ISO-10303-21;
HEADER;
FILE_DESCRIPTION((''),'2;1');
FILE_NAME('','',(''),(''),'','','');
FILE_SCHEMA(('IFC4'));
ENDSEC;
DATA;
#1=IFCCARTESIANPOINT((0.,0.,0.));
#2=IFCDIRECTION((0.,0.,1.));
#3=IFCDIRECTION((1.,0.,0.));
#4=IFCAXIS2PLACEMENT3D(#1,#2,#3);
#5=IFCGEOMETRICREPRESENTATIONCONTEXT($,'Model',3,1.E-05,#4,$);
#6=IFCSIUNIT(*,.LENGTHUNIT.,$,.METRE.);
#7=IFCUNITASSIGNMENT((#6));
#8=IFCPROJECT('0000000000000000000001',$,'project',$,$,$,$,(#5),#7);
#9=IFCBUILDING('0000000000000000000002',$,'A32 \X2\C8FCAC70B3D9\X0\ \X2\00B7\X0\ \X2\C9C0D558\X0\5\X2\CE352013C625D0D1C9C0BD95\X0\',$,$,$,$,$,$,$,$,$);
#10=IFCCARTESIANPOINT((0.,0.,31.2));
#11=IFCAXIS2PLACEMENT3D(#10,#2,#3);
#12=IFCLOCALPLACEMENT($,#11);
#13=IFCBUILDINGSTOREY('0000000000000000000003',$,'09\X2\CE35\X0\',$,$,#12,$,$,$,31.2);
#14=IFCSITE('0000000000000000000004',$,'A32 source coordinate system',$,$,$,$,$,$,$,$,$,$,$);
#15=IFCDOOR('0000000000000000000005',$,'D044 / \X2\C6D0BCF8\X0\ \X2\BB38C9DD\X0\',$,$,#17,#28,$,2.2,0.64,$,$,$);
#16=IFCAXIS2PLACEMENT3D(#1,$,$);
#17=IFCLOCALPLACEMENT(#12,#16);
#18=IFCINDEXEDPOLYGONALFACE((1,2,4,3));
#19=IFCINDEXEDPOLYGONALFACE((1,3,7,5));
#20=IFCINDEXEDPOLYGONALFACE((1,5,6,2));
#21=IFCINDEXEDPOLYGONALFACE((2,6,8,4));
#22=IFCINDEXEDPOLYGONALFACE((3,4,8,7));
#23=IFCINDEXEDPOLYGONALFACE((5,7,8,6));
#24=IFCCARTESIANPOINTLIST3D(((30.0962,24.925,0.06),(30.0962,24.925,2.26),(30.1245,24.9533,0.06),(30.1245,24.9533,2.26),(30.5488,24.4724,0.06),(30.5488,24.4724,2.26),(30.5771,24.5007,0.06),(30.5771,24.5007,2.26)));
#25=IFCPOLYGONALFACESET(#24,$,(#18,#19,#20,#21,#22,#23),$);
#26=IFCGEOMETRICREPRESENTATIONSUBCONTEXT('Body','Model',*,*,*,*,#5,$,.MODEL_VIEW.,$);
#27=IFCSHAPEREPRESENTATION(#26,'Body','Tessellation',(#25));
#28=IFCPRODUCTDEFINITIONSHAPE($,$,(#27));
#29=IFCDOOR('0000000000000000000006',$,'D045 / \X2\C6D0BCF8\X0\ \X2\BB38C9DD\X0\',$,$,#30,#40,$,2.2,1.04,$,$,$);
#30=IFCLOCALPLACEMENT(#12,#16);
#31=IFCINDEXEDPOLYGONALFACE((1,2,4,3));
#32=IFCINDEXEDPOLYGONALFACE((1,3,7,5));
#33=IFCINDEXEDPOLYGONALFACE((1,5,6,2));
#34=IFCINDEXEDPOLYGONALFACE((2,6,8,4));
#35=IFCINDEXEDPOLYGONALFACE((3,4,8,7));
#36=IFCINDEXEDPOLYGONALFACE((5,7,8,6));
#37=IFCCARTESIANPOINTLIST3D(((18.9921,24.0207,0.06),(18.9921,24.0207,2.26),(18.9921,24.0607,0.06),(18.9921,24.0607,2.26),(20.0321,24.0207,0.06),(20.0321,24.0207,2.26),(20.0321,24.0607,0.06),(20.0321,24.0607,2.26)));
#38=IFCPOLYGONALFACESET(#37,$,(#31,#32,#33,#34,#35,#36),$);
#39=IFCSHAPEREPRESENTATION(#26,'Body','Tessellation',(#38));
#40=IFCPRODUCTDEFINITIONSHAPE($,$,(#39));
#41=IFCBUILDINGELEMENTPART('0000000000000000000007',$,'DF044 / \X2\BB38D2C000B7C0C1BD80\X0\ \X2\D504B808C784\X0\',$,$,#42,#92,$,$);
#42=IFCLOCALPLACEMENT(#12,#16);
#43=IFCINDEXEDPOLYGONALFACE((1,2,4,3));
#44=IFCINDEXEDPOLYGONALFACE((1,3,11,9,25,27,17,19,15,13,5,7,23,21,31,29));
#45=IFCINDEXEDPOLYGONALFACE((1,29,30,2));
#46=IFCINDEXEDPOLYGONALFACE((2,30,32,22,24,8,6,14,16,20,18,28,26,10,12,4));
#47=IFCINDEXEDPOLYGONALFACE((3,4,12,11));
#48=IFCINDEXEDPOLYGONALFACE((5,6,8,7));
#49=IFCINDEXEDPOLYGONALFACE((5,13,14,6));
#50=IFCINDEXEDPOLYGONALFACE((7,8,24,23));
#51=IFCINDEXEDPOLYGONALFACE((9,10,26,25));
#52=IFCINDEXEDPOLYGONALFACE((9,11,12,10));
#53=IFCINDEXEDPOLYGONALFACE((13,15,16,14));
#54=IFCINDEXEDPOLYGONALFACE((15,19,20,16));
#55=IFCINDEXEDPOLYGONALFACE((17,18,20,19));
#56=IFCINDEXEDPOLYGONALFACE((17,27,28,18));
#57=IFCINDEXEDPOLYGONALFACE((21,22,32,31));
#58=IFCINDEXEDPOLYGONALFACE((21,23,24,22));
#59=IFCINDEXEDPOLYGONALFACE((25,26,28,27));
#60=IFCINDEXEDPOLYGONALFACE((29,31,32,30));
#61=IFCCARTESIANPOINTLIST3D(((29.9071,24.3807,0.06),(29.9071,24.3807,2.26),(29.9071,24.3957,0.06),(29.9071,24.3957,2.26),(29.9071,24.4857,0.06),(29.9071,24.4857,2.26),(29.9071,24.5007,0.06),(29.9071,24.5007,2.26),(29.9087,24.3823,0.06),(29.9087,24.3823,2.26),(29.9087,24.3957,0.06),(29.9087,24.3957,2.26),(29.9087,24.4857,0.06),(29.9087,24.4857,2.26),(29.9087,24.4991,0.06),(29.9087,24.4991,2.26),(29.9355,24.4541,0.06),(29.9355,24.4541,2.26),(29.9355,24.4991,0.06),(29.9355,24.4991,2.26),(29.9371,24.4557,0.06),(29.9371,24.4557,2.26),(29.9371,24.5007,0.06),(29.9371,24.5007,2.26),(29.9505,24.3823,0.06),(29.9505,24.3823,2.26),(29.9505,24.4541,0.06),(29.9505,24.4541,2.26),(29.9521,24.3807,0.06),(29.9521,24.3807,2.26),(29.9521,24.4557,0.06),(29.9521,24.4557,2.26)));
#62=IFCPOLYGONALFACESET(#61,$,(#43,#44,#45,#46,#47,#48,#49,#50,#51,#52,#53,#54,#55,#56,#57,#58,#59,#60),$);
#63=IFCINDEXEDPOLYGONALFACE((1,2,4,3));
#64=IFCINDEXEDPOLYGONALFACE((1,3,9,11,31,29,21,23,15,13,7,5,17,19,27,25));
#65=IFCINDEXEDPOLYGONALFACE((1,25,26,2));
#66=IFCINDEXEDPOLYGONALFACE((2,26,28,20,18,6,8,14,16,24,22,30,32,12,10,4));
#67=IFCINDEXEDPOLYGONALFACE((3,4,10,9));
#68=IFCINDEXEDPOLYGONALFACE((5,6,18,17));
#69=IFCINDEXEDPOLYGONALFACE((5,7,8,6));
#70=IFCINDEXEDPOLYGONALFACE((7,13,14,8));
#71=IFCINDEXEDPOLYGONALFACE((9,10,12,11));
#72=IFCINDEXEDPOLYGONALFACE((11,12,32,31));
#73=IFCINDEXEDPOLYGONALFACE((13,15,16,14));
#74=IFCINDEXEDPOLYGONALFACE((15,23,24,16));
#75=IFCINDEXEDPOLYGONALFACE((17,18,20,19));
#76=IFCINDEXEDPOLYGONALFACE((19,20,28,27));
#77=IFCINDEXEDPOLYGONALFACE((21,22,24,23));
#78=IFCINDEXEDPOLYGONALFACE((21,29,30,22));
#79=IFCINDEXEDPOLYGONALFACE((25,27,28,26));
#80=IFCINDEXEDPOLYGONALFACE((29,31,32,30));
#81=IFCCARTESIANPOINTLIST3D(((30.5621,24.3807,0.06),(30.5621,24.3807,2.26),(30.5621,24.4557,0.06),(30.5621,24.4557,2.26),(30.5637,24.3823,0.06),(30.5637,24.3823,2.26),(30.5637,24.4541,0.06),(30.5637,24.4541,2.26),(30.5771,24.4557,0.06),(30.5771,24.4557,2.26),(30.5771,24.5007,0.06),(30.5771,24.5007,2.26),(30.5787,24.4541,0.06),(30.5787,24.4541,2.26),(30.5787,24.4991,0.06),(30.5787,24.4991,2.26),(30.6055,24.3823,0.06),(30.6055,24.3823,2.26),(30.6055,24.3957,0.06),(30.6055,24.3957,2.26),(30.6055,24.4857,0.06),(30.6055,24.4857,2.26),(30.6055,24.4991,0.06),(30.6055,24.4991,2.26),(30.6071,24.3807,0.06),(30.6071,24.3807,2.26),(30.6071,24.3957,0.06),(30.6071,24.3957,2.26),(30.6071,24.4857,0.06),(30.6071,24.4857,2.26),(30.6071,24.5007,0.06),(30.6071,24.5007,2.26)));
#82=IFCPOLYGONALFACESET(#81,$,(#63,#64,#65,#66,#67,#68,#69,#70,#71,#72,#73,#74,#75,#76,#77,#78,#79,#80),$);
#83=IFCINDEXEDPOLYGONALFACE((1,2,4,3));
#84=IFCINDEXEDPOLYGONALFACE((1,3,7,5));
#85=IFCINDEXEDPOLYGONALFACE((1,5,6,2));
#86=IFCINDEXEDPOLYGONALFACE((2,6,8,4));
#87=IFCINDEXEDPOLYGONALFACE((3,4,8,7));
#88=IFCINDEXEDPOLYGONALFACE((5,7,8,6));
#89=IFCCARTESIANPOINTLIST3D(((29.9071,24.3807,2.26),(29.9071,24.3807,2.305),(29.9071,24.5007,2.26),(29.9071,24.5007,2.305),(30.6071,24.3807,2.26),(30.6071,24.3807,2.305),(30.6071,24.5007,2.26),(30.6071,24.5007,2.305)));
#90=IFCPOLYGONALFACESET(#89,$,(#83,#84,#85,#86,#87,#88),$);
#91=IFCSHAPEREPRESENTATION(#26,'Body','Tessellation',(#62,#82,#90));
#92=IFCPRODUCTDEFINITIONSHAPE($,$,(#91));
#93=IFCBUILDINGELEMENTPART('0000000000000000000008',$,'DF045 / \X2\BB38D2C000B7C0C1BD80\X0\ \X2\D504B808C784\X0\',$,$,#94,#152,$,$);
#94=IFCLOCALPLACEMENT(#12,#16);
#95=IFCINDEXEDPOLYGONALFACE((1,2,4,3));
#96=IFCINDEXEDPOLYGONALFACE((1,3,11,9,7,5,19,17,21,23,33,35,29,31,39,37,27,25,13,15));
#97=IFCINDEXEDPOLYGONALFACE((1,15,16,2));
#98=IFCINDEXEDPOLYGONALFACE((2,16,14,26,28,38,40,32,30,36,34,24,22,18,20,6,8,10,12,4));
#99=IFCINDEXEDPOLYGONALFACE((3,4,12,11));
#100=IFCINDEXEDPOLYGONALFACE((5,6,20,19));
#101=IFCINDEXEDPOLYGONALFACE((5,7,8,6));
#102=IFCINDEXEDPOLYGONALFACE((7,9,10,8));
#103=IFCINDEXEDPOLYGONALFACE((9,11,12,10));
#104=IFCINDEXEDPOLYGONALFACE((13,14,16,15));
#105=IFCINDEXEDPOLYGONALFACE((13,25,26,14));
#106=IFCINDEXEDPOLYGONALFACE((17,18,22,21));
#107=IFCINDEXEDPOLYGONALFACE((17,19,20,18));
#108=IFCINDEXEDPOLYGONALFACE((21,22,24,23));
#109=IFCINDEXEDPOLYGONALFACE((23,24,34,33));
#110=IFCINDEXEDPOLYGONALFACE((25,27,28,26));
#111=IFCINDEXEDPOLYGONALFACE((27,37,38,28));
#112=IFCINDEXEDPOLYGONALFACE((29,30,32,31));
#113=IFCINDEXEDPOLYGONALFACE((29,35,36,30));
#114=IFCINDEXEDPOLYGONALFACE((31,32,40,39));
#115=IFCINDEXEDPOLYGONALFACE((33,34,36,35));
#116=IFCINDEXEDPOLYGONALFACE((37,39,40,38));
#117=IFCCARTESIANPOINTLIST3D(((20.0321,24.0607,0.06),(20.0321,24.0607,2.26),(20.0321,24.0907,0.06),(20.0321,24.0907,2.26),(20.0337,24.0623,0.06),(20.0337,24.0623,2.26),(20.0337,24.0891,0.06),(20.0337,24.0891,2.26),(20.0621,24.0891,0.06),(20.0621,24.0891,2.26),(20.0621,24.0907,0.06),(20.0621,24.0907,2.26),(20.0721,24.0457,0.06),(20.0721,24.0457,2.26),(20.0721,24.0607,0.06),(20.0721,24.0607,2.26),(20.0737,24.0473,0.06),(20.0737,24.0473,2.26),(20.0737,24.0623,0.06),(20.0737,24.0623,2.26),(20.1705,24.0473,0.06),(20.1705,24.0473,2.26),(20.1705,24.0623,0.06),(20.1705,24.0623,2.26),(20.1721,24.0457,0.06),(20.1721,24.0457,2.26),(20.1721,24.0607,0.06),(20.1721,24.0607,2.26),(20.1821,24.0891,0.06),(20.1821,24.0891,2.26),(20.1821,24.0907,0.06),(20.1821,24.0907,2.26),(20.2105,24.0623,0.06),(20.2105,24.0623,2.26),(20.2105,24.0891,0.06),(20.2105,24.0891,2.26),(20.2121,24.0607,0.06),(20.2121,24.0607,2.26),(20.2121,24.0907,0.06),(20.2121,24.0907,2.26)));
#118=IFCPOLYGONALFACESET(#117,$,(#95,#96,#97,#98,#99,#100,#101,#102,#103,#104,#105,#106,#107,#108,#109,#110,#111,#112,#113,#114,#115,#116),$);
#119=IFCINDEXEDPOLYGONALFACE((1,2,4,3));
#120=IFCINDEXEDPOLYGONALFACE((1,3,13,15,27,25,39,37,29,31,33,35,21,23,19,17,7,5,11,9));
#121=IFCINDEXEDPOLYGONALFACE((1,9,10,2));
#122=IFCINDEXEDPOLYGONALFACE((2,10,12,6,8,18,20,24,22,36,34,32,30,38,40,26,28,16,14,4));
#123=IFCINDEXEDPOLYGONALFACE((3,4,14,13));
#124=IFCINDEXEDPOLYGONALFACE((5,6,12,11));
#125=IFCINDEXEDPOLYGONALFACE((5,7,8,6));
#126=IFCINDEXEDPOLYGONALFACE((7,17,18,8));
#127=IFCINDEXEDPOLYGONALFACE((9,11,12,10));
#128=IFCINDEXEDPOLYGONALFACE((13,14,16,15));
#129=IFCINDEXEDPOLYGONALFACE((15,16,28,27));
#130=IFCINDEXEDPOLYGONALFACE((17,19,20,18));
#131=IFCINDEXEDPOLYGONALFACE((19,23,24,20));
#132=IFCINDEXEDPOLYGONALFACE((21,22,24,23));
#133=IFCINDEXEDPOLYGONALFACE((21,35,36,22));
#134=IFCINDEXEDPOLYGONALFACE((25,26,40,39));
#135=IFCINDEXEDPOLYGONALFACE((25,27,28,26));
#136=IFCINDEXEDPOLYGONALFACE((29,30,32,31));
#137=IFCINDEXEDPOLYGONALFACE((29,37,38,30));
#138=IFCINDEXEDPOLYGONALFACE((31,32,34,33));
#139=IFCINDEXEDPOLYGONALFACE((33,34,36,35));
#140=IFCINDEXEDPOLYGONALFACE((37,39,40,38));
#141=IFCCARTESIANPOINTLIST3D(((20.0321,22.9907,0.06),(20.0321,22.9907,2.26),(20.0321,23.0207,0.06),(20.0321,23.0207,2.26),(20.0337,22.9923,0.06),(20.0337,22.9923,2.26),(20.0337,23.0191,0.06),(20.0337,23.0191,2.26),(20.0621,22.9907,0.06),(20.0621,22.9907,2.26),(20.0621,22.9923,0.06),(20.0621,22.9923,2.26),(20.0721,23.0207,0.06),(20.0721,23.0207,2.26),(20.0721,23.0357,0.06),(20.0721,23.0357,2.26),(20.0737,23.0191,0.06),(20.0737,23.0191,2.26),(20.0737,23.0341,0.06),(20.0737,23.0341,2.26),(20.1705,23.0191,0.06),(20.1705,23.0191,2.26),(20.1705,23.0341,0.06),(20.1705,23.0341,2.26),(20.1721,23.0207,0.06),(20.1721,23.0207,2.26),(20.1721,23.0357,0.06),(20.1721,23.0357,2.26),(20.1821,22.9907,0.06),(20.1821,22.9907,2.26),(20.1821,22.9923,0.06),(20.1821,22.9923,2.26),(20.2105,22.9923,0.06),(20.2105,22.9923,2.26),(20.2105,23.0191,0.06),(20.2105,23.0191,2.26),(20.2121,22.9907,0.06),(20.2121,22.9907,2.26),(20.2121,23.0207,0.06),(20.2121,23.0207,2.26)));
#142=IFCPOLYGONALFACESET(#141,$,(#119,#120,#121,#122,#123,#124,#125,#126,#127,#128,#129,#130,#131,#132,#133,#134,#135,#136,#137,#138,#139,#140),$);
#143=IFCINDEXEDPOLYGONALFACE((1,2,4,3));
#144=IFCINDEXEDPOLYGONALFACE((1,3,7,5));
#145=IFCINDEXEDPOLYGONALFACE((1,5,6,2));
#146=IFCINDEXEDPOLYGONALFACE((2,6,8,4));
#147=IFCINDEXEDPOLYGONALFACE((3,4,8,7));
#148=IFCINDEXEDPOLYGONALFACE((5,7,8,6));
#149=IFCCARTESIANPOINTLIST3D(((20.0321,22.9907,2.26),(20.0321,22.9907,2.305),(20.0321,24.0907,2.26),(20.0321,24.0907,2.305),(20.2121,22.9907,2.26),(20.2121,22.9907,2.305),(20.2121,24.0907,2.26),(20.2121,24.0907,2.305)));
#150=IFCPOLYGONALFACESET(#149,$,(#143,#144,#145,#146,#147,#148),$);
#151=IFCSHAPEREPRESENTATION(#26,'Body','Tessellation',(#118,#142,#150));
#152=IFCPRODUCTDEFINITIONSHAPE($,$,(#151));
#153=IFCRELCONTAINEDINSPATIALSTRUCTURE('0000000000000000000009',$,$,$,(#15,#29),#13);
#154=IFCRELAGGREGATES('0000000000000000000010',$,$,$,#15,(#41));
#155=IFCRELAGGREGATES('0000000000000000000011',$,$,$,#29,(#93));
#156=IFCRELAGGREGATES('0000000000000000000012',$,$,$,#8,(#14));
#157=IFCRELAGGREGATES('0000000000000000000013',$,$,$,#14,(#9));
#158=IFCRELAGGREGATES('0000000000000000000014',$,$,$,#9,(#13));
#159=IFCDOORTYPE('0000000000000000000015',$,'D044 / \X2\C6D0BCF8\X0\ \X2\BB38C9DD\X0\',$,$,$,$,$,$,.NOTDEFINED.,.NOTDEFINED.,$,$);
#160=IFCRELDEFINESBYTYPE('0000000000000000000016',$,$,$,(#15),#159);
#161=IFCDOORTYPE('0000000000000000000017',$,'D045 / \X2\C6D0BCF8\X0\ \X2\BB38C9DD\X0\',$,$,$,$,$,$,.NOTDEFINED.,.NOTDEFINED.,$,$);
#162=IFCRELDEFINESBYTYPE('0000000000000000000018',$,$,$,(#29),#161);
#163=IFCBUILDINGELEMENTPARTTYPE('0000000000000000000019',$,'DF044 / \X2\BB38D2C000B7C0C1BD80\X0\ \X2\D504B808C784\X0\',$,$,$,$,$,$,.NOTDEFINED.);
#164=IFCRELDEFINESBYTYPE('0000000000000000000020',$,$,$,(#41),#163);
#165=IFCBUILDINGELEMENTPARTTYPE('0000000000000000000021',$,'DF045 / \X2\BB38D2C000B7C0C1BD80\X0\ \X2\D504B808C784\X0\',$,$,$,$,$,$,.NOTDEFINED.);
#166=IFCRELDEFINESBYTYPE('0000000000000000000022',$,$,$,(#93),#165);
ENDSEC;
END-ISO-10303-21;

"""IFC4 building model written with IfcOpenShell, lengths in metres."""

from ifc_helpers import new_model, si_unit, frame, origin, origin_with_axes, place, context, subcontext, project, spatial, polyline, outline, extrude, source, transform, mapped, type_object, type_shapes, element, aggregate, save


model = new_model("IFC4")

# Units and contexts
model_context = context("Model", 3, precision=1e-05, world=origin_with_axes())
body_context = subcontext(model_context, "Body", "Model", "MODEL_VIEW")
ifc_project = project(units=[si_unit("LENGTHUNIT", "METRE")], contexts=[model_context])

# Site, building, storey
storey_placement = place(None, frame((0.0, 0.0, 31.2), z_axis=(0.0, 0.0, 1.0), x_axis=(1.0, 0.0, 0.0)))
site = spatial("IfcSite", under=ifc_project, Name="A32 source coordinate system")
building = spatial("IfcBuilding", under=site, Name="A32 주거동 · 지하5층–옥탑지붕")
storey = spatial("IfcBuildingStorey", under=building, at=storey_placement, Name="09층", Elevation=31.2)

# Doors
door_type_1 = type_object("IfcDoorType", Name="D044 / 원본 문짝", OperationType="NOTDEFINED", PredefinedType="NOTDEFINED")
shared_shape_1 = source(origin(), body_context, "Body", "SweptSolid", [
    extrude(outline(polyline([(30.5771, 24.5007), (30.5488, 24.4724), (30.0962, 24.925), (30.1245, 24.9533), (30.5771, 24.5007)])), frame((0.0, 0.0, 0.06)), (0.0, 0.0, 1.0), 2.2),
])
type_shapes(door_type_1, [shared_shape_1])
door_1_placement = place(storey_placement, origin_with_axes())
door_1 = element("IfcDoor", 1, at=door_1_placement, inside=storey, type_object=door_type_1, Name="D044 / 원본 문짝", OverallHeight=2.2, OverallWidth=0.64, context=body_context, shape_type="MappedRepresentation", body=[
    mapped(shared_shape_1, transform((0.0, 0.0, 0.0), scale=1.0)),
])
door_type_2 = type_object("IfcDoorType", Name="D045 / 원본 문짝", OperationType="NOTDEFINED", PredefinedType="NOTDEFINED")
shared_shape_2 = source(origin(), body_context, "Body", "SweptSolid", [
    extrude(outline(polyline([(20.0321, 24.0607), (20.0321, 24.0207), (18.9921, 24.0207), (18.9921, 24.0607), (20.0321, 24.0607)])), frame((0.0, 0.0, 0.06)), (0.0, 0.0, 1.0), 2.2),
])
type_shapes(door_type_2, [shared_shape_2])
door_2_placement = place(storey_placement, origin_with_axes())
door_2 = element("IfcDoor", 2, at=door_2_placement, inside=storey, type_object=door_type_2, Name="D045 / 원본 문짝", OverallHeight=2.2, OverallWidth=1.04, context=body_context, shape_type="MappedRepresentation", body=[
    mapped(shared_shape_2, transform((0.0, 0.0, 0.0), scale=1.0)),
])

# Building element parts
building_element_part_type_1 = type_object("IfcBuildingElementPartType", Name="DF044 / 문틀·상부 프레임", PredefinedType="NOTDEFINED")
shared_shape_3 = source(origin(), body_context, "Body", "SweptSolid", [
    extrude(outline(polyline([(29.9071, 24.4857), (29.9071, 24.5007), (29.9371, 24.5007), (29.9371, 24.4557), (29.9521, 24.4557), (29.9521, 24.3807), (29.9071, 24.3807), (29.9071, 24.3957), (29.9087, 24.3957), (29.9087, 24.3823), (29.9505, 24.3823), (29.9505, 24.4541), (29.9355, 24.4541), (29.9355, 24.4991), (29.9087, 24.4991), (29.9087, 24.4857), (29.9071, 24.4857)])), frame((0.0, 0.0, 0.06)), (0.0, 0.0, 1.0), 2.2),
    extrude(outline(polyline([(30.6055, 24.4991), (30.5787, 24.4991), (30.5787, 24.4541), (30.5637, 24.4541), (30.5637, 24.3823), (30.6055, 24.3823), (30.6055, 24.3957), (30.6071, 24.3957), (30.6071, 24.3807), (30.5621, 24.3807), (30.5621, 24.4557), (30.5771, 24.4557), (30.5771, 24.5007), (30.6071, 24.5007), (30.6071, 24.4857), (30.6055, 24.4857), (30.6055, 24.4991)])), frame((0.0, 0.0, 0.06)), (0.0, 0.0, 1.0), 2.2),
    extrude(outline(polyline([(29.9071, 24.3807), (29.9071, 24.5007), (30.6071, 24.5007), (30.6071, 24.3807), (29.9071, 24.3807)])), frame((0.0, 0.0, 2.26)), (0.0, 0.0, 1.0), 0.045),
])
type_shapes(building_element_part_type_1, [shared_shape_3])
building_element_part_1_placement = place(door_1_placement, origin_with_axes())
building_element_part_1 = element("IfcBuildingElementPart", 3, at=building_element_part_1_placement, type_object=building_element_part_type_1, Name="DF044 / 문틀·상부 프레임", context=body_context, shape_type="MappedRepresentation", body=[
    mapped(shared_shape_3, transform((0.0, 0.0, 0.0), scale=1.0)),
])
aggregate(door_1, [building_element_part_1])
building_element_part_type_2 = type_object("IfcBuildingElementPartType", Name="DF045 / 문틀·상부 프레임", PredefinedType="NOTDEFINED")
shared_shape_4 = source(origin(), body_context, "Body", "SweptSolid", [
    extrude(outline(polyline([(20.0337, 24.0891), (20.0337, 24.0623), (20.0737, 24.0623), (20.0737, 24.0473), (20.1705, 24.0473), (20.1705, 24.0623), (20.2105, 24.0623), (20.2105, 24.0891), (20.1821, 24.0891), (20.1821, 24.0907), (20.2121, 24.0907), (20.2121, 24.0607), (20.1721, 24.0607), (20.1721, 24.0457), (20.0721, 24.0457), (20.0721, 24.0607), (20.0321, 24.0607), (20.0321, 24.0907), (20.0621, 24.0907), (20.0621, 24.0891), (20.0337, 24.0891)])), frame((0.0, 0.0, 0.06)), (0.0, 0.0, 1.0), 2.2),
    extrude(outline(polyline([(20.0621, 22.9907), (20.0321, 22.9907), (20.0321, 23.0207), (20.0721, 23.0207), (20.0721, 23.0357), (20.1721, 23.0357), (20.1721, 23.0207), (20.2121, 23.0207), (20.2121, 22.9907), (20.1821, 22.9907), (20.1821, 22.9923), (20.2105, 22.9923), (20.2105, 23.0191), (20.1705, 23.0191), (20.1705, 23.0341), (20.0737, 23.0341), (20.0737, 23.0191), (20.0337, 23.0191), (20.0337, 22.9923), (20.0621, 22.9923), (20.0621, 22.9907)])), frame((0.0, 0.0, 0.06)), (0.0, 0.0, 1.0), 2.2),
    extrude(outline(polyline([(20.0321, 22.9907), (20.0321, 24.0907), (20.2121, 24.0907), (20.2121, 22.9907), (20.0321, 22.9907)])), frame((0.0, 0.0, 2.26)), (0.0, 0.0, 1.0), 0.045),
])
type_shapes(building_element_part_type_2, [shared_shape_4])
building_element_part_2_placement = place(door_2_placement, origin_with_axes())
building_element_part_2 = element("IfcBuildingElementPart", 4, at=building_element_part_2_placement, type_object=building_element_part_type_2, Name="DF045 / 문틀·상부 프레임", context=body_context, shape_type="MappedRepresentation", body=[
    mapped(shared_shape_4, transform((0.0, 0.0, 0.0), scale=1.0)),
])
aggregate(door_2, [building_element_part_2])

save(model, "model.ifc")
